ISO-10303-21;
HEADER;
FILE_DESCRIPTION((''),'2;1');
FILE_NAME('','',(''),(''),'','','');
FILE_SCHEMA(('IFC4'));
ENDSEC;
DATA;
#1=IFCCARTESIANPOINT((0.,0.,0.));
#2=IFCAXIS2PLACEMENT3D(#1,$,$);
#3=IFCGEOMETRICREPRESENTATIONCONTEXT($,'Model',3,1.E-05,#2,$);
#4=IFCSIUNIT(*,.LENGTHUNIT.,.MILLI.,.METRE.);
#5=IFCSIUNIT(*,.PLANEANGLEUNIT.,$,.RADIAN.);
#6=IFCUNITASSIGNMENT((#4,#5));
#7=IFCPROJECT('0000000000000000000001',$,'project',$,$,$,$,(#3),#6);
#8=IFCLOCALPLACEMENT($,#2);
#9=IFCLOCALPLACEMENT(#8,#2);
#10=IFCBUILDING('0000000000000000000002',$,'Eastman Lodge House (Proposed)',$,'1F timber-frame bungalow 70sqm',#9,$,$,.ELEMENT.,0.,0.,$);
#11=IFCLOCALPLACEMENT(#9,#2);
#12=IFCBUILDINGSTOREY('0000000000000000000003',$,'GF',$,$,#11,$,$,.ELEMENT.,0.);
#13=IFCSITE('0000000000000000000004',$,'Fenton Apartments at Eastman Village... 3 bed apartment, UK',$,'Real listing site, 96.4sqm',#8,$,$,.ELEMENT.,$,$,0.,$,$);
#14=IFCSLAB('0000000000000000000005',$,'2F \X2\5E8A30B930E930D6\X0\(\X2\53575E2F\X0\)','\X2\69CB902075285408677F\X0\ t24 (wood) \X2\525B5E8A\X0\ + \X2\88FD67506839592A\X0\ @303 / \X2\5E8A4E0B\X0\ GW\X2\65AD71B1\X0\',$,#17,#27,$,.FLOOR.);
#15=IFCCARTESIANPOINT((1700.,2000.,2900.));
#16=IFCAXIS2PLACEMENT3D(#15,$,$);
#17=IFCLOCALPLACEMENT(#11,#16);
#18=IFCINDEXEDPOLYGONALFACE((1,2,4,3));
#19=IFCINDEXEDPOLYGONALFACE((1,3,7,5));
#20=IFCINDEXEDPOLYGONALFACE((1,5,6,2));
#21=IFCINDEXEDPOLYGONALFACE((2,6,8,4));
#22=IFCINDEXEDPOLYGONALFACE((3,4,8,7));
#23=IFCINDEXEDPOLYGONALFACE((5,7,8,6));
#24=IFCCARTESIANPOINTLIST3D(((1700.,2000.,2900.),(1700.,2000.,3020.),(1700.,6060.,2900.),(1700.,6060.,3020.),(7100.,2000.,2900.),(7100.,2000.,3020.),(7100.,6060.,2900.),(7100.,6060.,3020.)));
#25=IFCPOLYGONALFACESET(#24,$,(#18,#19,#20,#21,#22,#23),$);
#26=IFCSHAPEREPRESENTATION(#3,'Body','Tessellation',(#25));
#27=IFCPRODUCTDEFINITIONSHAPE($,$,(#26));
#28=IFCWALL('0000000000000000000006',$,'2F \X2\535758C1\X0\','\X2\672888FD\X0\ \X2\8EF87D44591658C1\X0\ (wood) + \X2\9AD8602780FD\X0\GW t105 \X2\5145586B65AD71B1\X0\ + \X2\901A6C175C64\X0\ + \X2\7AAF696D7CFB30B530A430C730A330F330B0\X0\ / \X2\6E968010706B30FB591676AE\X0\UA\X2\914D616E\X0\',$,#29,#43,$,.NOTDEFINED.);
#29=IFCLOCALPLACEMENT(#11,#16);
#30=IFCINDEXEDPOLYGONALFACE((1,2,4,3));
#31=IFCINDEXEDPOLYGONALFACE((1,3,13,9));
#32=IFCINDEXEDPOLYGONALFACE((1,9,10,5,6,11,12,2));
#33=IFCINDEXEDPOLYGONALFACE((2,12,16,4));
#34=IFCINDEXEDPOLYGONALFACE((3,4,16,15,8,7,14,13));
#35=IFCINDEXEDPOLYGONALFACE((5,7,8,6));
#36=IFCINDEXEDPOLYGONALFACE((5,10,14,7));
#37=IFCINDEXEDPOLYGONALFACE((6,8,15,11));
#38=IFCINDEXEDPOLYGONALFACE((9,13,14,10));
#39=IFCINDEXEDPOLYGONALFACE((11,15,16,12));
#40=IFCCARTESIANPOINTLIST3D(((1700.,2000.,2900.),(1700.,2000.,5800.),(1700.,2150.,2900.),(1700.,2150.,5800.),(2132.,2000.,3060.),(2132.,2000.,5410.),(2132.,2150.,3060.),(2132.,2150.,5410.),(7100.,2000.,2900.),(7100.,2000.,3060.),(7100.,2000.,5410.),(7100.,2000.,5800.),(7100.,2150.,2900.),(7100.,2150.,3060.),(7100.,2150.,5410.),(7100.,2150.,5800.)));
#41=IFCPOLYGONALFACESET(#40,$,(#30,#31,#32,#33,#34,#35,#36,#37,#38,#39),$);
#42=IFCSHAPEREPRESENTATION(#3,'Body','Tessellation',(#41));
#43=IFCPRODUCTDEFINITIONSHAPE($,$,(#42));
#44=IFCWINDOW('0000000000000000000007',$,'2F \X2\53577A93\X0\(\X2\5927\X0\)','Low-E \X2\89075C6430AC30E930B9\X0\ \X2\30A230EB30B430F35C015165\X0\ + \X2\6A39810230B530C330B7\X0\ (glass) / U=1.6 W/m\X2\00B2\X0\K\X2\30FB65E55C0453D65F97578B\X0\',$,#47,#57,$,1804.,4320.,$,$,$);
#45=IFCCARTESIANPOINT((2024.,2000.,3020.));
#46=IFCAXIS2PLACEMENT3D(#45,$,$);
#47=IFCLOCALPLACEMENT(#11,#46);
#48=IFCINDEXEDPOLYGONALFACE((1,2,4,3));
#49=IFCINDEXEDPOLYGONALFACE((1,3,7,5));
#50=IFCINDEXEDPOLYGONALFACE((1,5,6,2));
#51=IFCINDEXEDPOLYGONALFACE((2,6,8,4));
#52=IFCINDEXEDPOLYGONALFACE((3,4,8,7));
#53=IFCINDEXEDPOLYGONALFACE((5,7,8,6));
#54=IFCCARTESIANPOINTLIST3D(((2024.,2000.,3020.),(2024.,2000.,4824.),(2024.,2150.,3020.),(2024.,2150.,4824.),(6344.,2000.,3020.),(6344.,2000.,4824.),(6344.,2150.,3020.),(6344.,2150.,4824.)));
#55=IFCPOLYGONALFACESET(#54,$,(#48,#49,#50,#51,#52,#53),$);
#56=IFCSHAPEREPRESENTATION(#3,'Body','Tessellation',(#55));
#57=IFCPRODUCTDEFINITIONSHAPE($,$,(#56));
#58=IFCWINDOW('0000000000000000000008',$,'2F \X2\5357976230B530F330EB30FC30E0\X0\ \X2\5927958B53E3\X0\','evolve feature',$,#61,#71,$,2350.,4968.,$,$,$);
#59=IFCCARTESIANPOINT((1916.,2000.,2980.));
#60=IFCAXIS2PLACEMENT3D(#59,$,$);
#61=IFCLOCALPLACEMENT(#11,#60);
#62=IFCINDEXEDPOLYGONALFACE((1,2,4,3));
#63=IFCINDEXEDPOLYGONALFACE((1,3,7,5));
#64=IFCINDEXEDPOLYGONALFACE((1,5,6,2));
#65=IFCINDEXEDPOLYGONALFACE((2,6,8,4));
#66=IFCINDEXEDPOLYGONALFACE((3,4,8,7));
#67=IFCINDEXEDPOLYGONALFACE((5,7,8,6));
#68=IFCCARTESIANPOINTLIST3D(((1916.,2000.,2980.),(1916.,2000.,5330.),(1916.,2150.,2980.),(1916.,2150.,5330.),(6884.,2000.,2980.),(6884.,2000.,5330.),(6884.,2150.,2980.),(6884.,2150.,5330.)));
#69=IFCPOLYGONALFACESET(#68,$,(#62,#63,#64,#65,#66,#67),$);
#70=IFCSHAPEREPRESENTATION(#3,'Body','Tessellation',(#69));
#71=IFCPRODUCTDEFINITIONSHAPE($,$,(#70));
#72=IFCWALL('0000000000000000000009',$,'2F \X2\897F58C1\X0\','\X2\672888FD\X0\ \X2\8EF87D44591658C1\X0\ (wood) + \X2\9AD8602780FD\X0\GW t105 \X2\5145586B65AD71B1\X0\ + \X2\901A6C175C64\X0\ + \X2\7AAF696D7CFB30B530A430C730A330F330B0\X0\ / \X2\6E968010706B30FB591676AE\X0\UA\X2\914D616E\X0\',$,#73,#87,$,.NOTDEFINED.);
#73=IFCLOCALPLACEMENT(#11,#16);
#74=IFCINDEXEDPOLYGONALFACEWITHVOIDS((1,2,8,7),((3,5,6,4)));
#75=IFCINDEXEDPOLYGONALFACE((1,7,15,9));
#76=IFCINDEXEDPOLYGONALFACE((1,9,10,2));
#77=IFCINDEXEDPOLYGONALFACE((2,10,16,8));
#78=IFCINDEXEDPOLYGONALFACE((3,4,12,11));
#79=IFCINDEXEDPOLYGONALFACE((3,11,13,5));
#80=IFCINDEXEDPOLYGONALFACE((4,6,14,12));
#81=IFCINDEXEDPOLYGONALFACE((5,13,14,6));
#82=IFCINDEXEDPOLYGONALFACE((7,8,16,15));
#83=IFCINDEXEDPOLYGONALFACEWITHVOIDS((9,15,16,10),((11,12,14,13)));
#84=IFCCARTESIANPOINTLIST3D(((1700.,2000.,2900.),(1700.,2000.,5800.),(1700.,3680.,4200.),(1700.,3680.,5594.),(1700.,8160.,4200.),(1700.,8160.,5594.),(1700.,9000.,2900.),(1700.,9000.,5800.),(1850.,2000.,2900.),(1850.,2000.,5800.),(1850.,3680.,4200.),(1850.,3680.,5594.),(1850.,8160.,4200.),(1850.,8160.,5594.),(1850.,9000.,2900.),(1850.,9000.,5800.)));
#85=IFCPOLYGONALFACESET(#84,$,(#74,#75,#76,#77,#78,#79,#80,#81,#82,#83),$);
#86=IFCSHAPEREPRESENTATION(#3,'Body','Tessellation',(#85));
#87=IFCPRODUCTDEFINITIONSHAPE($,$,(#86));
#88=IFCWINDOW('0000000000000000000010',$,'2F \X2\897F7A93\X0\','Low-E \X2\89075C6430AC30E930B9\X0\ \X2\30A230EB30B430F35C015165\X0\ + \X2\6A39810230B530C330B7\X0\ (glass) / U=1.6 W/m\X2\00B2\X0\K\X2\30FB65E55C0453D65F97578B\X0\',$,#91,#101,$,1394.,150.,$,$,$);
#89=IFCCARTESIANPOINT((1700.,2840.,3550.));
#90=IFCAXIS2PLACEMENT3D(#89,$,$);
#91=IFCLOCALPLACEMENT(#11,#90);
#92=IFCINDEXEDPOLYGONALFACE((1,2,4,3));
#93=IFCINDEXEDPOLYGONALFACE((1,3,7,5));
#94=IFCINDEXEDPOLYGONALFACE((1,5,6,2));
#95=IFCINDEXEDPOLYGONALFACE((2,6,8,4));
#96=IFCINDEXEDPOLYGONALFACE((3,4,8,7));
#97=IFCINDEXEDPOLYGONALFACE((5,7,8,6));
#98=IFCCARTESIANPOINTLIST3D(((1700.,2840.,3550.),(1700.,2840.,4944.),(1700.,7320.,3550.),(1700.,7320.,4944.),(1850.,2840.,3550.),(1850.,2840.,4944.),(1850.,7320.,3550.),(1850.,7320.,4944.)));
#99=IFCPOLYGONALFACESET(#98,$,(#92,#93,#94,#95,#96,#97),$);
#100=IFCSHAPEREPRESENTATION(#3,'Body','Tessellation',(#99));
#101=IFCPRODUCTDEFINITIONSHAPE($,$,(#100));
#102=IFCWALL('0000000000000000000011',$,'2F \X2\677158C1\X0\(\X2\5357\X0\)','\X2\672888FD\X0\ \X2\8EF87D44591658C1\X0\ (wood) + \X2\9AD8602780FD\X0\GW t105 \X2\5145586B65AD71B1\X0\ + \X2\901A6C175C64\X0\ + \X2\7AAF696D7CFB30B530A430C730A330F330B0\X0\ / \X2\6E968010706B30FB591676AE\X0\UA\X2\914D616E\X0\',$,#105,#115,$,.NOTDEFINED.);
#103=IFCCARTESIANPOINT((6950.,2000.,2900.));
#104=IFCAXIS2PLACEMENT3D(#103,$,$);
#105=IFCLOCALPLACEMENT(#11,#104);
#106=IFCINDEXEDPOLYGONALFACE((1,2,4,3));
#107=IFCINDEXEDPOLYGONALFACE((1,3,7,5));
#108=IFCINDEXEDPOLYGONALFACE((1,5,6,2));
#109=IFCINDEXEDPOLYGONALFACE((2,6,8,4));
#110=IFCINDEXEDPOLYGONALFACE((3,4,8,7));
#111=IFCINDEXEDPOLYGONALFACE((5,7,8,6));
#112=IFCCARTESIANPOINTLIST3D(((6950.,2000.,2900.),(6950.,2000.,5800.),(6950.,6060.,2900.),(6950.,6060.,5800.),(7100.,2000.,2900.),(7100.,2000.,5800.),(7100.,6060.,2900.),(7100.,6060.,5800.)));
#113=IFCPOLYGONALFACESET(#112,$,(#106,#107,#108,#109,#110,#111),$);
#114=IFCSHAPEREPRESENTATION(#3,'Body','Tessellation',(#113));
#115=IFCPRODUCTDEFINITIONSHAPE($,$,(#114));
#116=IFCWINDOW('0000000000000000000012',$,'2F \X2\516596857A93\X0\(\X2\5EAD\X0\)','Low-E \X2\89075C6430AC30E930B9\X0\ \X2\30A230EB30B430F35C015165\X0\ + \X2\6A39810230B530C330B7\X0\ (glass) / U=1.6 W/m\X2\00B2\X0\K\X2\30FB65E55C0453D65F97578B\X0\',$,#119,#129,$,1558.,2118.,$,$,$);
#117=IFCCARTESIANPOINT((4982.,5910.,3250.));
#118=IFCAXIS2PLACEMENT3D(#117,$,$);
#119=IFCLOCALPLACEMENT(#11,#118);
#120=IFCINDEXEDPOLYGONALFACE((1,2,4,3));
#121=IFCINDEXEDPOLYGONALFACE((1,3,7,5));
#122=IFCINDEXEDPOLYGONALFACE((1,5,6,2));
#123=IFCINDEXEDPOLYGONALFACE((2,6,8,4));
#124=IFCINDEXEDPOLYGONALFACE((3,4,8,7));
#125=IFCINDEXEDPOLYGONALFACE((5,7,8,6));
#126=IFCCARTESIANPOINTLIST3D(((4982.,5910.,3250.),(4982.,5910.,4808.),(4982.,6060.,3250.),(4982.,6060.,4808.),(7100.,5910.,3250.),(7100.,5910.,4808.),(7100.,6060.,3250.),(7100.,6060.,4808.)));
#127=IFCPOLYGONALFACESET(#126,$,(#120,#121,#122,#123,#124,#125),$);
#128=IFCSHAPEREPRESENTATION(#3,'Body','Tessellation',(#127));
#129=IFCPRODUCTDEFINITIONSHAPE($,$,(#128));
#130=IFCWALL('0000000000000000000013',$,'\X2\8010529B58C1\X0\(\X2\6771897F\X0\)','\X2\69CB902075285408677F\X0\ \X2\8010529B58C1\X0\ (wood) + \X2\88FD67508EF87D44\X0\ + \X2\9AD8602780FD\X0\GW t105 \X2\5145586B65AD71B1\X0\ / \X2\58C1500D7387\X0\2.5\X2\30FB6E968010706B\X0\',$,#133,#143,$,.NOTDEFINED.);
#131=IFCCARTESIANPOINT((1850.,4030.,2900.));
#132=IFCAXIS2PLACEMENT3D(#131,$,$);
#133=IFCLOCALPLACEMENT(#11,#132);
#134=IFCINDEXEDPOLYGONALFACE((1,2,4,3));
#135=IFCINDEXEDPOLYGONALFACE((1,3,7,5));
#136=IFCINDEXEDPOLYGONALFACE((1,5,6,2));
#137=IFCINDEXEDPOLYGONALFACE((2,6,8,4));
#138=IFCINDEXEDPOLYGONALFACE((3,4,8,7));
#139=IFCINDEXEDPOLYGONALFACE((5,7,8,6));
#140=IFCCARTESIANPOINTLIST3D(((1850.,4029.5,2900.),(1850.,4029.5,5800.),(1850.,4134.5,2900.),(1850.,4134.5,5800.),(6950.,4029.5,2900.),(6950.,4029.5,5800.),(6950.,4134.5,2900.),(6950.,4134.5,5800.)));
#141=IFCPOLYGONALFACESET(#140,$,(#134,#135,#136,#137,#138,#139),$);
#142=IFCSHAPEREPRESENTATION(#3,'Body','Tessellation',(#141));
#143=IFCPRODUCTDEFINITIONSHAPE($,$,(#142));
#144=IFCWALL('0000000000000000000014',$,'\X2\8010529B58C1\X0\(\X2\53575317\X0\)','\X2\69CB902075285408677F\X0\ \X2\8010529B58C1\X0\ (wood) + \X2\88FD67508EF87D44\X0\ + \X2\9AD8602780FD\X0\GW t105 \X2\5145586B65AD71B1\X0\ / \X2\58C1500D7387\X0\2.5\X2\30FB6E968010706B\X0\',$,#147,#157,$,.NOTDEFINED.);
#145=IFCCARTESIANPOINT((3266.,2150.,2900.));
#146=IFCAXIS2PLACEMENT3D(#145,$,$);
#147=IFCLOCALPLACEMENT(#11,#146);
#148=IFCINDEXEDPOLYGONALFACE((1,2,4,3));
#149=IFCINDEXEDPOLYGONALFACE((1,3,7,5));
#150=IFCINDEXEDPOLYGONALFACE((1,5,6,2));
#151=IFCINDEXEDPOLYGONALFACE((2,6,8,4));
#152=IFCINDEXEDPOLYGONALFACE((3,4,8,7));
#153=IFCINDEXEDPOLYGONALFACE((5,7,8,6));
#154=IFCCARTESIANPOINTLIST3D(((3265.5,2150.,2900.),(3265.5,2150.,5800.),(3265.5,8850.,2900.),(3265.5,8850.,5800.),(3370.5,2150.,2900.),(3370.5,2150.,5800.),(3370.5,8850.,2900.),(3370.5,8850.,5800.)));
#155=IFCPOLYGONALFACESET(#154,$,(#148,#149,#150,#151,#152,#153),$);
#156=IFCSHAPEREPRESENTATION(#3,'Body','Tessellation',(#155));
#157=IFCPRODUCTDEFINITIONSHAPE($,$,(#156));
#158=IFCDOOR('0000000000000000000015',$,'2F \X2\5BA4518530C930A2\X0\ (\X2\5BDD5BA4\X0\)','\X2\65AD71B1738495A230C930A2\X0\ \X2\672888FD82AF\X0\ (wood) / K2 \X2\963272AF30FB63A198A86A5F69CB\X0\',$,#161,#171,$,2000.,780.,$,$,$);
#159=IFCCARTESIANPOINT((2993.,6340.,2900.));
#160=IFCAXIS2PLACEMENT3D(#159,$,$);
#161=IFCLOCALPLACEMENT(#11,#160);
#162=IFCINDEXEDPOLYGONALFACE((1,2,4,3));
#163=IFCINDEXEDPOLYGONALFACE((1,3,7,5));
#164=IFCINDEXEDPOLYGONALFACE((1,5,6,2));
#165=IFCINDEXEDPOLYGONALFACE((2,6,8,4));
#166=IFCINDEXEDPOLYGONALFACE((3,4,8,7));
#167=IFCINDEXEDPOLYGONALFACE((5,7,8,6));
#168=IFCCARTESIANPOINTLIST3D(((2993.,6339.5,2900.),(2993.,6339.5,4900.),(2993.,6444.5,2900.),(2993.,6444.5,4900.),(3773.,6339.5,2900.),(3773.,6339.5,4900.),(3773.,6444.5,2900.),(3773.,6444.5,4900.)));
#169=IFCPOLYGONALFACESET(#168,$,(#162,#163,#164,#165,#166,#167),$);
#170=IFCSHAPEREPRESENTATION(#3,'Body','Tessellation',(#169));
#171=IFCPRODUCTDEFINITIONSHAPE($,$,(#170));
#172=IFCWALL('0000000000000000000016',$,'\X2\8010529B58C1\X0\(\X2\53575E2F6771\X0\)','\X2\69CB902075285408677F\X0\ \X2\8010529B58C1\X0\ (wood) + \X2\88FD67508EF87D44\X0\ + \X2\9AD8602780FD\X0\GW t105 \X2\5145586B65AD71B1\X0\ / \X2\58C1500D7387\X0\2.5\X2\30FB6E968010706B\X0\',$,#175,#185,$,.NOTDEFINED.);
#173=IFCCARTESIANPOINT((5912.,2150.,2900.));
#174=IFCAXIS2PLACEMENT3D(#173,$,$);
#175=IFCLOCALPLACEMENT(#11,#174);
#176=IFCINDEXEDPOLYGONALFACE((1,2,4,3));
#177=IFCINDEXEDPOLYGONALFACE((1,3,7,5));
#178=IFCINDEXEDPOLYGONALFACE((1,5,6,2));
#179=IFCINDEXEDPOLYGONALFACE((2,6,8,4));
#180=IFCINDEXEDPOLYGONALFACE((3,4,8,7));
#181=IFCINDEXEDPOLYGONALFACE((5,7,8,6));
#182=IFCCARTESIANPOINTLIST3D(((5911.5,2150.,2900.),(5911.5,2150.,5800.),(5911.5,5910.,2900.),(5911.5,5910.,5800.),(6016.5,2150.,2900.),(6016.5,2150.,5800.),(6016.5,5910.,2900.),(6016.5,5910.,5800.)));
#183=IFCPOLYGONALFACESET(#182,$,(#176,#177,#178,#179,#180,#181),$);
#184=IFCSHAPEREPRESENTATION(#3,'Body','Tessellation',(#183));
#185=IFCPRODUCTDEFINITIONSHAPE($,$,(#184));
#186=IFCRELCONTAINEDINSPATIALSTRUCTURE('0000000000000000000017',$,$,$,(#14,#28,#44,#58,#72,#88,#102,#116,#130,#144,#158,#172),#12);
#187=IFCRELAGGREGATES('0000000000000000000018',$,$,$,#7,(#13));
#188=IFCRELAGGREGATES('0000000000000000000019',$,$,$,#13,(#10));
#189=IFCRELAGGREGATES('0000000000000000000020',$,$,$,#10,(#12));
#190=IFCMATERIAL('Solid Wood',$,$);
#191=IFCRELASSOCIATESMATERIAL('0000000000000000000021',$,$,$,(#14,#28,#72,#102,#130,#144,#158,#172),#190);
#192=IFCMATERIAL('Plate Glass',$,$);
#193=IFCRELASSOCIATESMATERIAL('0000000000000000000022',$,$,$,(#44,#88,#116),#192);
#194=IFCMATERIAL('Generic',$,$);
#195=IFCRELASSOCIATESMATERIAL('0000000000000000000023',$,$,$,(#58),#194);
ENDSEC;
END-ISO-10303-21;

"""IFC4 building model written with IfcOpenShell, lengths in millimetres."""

from ifc_helpers import new_model, si_unit, frame, frame_2d, origin, place, context, project, spatial, rectangle, extrude, material, element, fill, save


model = new_model("IFC4")

# Units and contexts
model_context = context("Model", 3, precision=1e-05, world=origin())
ifc_project = project(units=[si_unit("LENGTHUNIT", "METRE", prefix="MILLI"), si_unit("PLANEANGLEUNIT", "RADIAN")], contexts=[model_context])

# Site, building, storey
site_placement = place(None, origin())
site = spatial("IfcSite", under=ifc_project, at=site_placement, Name="Fenton Apartments at Eastman Village... 3 bed apartment, UK", ObjectType="Real listing site, 96.4sqm", CompositionType="ELEMENT", RefElevation=0.0)
building_placement = place(site_placement, origin())
building = spatial("IfcBuilding", under=site, at=building_placement, Name="Eastman Lodge House (Proposed)", ObjectType="1F timber-frame bungalow 70sqm", CompositionType="ELEMENT", ElevationOfRefHeight=0.0, ElevationOfTerrain=0.0)
storey_placement = place(building_placement, origin())
storey = spatial("IfcBuildingStorey", under=building, at=storey_placement, Name="GF", CompositionType="ELEMENT", Elevation=0.0)

# Slab
ifc_material_1 = material(Name="Solid Wood")
slab_placement = place(storey_placement, frame((1700.0, 2000.0, 2900.0)))
element("IfcSlab", 1, at=slab_placement, inside=storey, material=ifc_material_1, Name="2F 床スラブ(南帯)", Description="構造用合板 t24 (wood) 剛床 + 製材根太 @303 / 床下 GW断熱", PredefinedType="FLOOR", context=model_context, shape_type="SweptSolid", body=[
    extrude(rectangle(XDim=5400.0, YDim=4060.0, at=frame_2d((2700.0, 2030.0))), frame((1700.0, 2000.0, 2900.0)), (0.0, 0.0, 1.0), 120.0),
])

# Wall, openings, windows
wall_1_placement = place(storey_placement, frame((1700.0, 2000.0, 2900.0)))
wall_1 = element("IfcWall", 2, at=wall_1_placement, inside=storey, material=ifc_material_1, Name="2F 南壁", Description="木製 軸組外壁 (wood) + 高性能GW t105 充填断熱 + 通気層 + 窯業系サイディング / 準耐火・外皮UA配慮", PredefinedType="NOTDEFINED", context=model_context, shape_type="SweptSolid", body=[
    extrude(rectangle(XDim=5400.0, YDim=150.0, at=frame_2d((2700.0, 75.0))), frame((1700.0, 2000.0, 2900.0)), (0.0, 0.0, 1.0), 2900.0),
])
opening_1_placement = place(storey_placement, frame((2024.0, 2000.0, 3020.0)))
opening_1 = element("IfcOpeningElement", 3, at=opening_1_placement, cuts=wall_1, PredefinedType="NOTDEFINED", context=model_context, shape_type="SweptSolid", body=[
    extrude(rectangle(XDim=4320.0, YDim=150.0, at=frame_2d((2160.0, 75.0))), frame((2024.0, 2000.0, 3020.0)), (0.0, 0.0, 1.0), 1804.0),
])
opening_2_placement = place(storey_placement, frame((1916.0, 2000.0, 2980.0)))
opening_2 = element("IfcOpeningElement", 4, at=opening_2_placement, cuts=wall_1, PredefinedType="NOTDEFINED", context=model_context, shape_type="SweptSolid", body=[
    extrude(rectangle(XDim=4968.0, YDim=150.0, at=frame_2d((2484.0, 75.0))), frame((1916.0, 2000.0, 2980.0)), (0.0, 0.0, 1.0), 2350.0),
])
ifc_material_2 = material(Name="Plate Glass")
window_1_placement = place(storey_placement, frame((2024.0, 2000.0, 3020.0)))
window_1 = element("IfcWindow", 5, at=window_1_placement, inside=storey, material=ifc_material_2, Name="2F 南窓(大)", Description="Low-E 複層ガラス アルゴン封入 + 樹脂サッシ (glass) / U=1.6 W/m²K・日射取得型", OverallHeight=1804.0, OverallWidth=4320.0, context=model_context, shape_type="SweptSolid", body=[
    extrude(rectangle(XDim=4320.0, YDim=150.0, at=frame_2d((2160.0, 75.0))), frame((2024.0, 2000.0, 3020.0)), (0.0, 0.0, 1.0), 1804.0),
])
fill(opening_1, window_1)
ifc_material_3 = material(Name="Generic")
window_2_placement = place(storey_placement, frame((1916.0, 2000.0, 2980.0)))
window_2 = element("IfcWindow", 6, at=window_2_placement, inside=storey, material=ifc_material_3, Name="2F 南面サンルーム 大開口", Description="evolve feature", OverallHeight=2350.0, OverallWidth=4968.0, context=model_context, shape_type="SweptSolid", body=[
    extrude(rectangle(XDim=4968.0, YDim=150.0, at=frame_2d((2484.0, 75.0))), frame((1916.0, 2000.0, 2980.0)), (0.0, 0.0, 1.0), 2350.0),
])
fill(opening_2, window_2)

# Walls, openings, windows
wall_2_placement = place(storey_placement, frame((1700.0, 2000.0, 2900.0)))
wall_2 = element("IfcWall", 7, at=wall_2_placement, inside=storey, material=ifc_material_1, Name="2F 西壁", Description="木製 軸組外壁 (wood) + 高性能GW t105 充填断熱 + 通気層 + 窯業系サイディング / 準耐火・外皮UA配慮", PredefinedType="NOTDEFINED", context=model_context, shape_type="SweptSolid", body=[
    extrude(rectangle(XDim=150.0, YDim=7000.0, at=frame_2d((75.0, 3500.0))), frame((1700.0, 2000.0, 2900.0)), (0.0, 0.0, 1.0), 2900.0),
])
opening_3_placement = place(storey_placement, frame((1700.0, 2840.0, 3550.0)))
opening_3 = element("IfcOpeningElement", 8, at=opening_3_placement, cuts=wall_2, PredefinedType="NOTDEFINED", context=model_context, shape_type="SweptSolid", body=[
    extrude(rectangle(XDim=150.0, YDim=4480.0, at=frame_2d((75.0, 2240.0))), frame((1700.0, 2840.0, 3550.0)), (0.0, 0.0, 1.0), 1394.0),
])
window_3_placement = place(storey_placement, frame((1700.0, 2840.0, 3550.0)))
window_3 = element("IfcWindow", 9, at=window_3_placement, inside=storey, material=ifc_material_2, Name="2F 西窓", Description="Low-E 複層ガラス アルゴン封入 + 樹脂サッシ (glass) / U=1.6 W/m²K・日射取得型", OverallHeight=1394.0, OverallWidth=150.0, context=model_context, shape_type="SweptSolid", body=[
    extrude(rectangle(XDim=150.0, YDim=4480.0, at=frame_2d((75.0, 2240.0))), frame((1700.0, 2840.0, 3550.0)), (0.0, 0.0, 1.0), 1394.0),
])
fill(opening_3, window_3)
wall_3_placement = place(storey_placement, frame((6950.0, 2000.0, 2900.0)))
wall_3 = element("IfcWall", 10, at=wall_3_placement, inside=storey, material=ifc_material_1, Name="2F 東壁(南)", Description="木製 軸組外壁 (wood) + 高性能GW t105 充填断熱 + 通気層 + 窯業系サイディング / 準耐火・外皮UA配慮", PredefinedType="NOTDEFINED", context=model_context, shape_type="SweptSolid", body=[
    extrude(rectangle(XDim=150.0, YDim=4060.0, at=frame_2d((75.0, 2030.0))), frame((6950.0, 2000.0, 2900.0)), (0.0, 0.0, 1.0), 2900.0),
])
opening_4_placement = place(storey_placement, frame((4982.0, 5910.0, 3250.0)))
opening_4 = element("IfcOpeningElement", 11, at=opening_4_placement, cuts=wall_3, PredefinedType="NOTDEFINED", context=model_context, shape_type="SweptSolid", body=[
    extrude(rectangle(XDim=2118.0, YDim=150.0, at=frame_2d((1059.0, 75.0))), frame((4982.0, 5910.0, 3250.0)), (0.0, 0.0, 1.0), 1558.0),
])
window_4_placement = place(storey_placement, frame((4982.0, 5910.0, 3250.0)))
window_4 = element("IfcWindow", 12, at=window_4_placement, inside=storey, material=ifc_material_2, Name="2F 入隅窓(庭)", Description="Low-E 複層ガラス アルゴン封入 + 樹脂サッシ (glass) / U=1.6 W/m²K・日射取得型", OverallHeight=1558.0, OverallWidth=2118.0, context=model_context, shape_type="SweptSolid", body=[
    extrude(rectangle(XDim=2118.0, YDim=150.0, at=frame_2d((1059.0, 75.0))), frame((4982.0, 5910.0, 3250.0)), (0.0, 0.0, 1.0), 1558.0),
])
fill(opening_4, window_4)

# Wall
wall_4_placement = place(storey_placement, frame((1850.0, 4030.0, 2900.0)))
element("IfcWall", 13, at=wall_4_placement, inside=storey, material=ifc_material_1, Name="耐力壁(東西)", Description="構造用合板 耐力壁 (wood) + 製材軸組 + 高性能GW t105 充填断熱 / 壁倍率2.5・準耐火", PredefinedType="NOTDEFINED", context=model_context, shape_type="SweptSolid", body=[
    extrude(rectangle(XDim=5100.0, YDim=105.0, at=frame_2d((2550.0, 52.0))), frame((1850.0, 4030.0, 2900.0)), (0.0, 0.0, 1.0), 2900.0),
])

# Wall, opening, door
wall_5_placement = place(storey_placement, frame((3266.0, 2150.0, 2900.0)))
wall_5 = element("IfcWall", 14, at=wall_5_placement, inside=storey, material=ifc_material_1, Name="耐力壁(南北)", Description="構造用合板 耐力壁 (wood) + 製材軸組 + 高性能GW t105 充填断熱 / 壁倍率2.5・準耐火", PredefinedType="NOTDEFINED", context=model_context, shape_type="SweptSolid", body=[
    extrude(rectangle(XDim=105.0, YDim=6700.0, at=frame_2d((52.0, 3350.0))), frame((3266.0, 2150.0, 2900.0)), (0.0, 0.0, 1.0), 2900.0),
])
opening_5_placement = place(storey_placement, frame((2993.0, 6340.0, 2900.0)))
opening_5 = element("IfcOpeningElement", 15, at=opening_5_placement, cuts=wall_5, PredefinedType="NOTDEFINED", context=model_context, shape_type="SweptSolid", body=[
    extrude(rectangle(XDim=780.0, YDim=105.0, at=frame_2d((390.0, 52.0))), frame((2993.0, 6340.0, 2900.0)), (0.0, 0.0, 1.0), 2000.0),
])
door_placement = place(storey_placement, frame((2993.0, 6340.0, 2900.0)))
door = element("IfcDoor", 16, at=door_placement, inside=storey, material=ifc_material_1, Name="2F 室内ドア (寝室)", Description="断熱玄関ドア 木製芯 (wood) / K2 防犯・採風機構", OverallHeight=2000.0, OverallWidth=780.0, context=model_context, shape_type="SweptSolid", body=[
    extrude(rectangle(XDim=780.0, YDim=105.0, at=frame_2d((390.0, 52.0))), frame((2993.0, 6340.0, 2900.0)), (0.0, 0.0, 1.0), 2000.0),
])
fill(opening_5, door)

# Wall
wall_6_placement = place(storey_placement, frame((5912.0, 2150.0, 2900.0)))
element("IfcWall", 17, at=wall_6_placement, inside=storey, material=ifc_material_1, Name="耐力壁(南帯東)", Description="構造用合板 耐力壁 (wood) + 製材軸組 + 高性能GW t105 充填断熱 / 壁倍率2.5・準耐火", PredefinedType="NOTDEFINED", context=model_context, shape_type="SweptSolid", body=[
    extrude(rectangle(XDim=105.0, YDim=3760.0, at=frame_2d((52.0, 1880.0))), frame((5912.0, 2150.0, 2900.0)), (0.0, 0.0, 1.0), 2900.0),
])

save(model, "model.ifc")
